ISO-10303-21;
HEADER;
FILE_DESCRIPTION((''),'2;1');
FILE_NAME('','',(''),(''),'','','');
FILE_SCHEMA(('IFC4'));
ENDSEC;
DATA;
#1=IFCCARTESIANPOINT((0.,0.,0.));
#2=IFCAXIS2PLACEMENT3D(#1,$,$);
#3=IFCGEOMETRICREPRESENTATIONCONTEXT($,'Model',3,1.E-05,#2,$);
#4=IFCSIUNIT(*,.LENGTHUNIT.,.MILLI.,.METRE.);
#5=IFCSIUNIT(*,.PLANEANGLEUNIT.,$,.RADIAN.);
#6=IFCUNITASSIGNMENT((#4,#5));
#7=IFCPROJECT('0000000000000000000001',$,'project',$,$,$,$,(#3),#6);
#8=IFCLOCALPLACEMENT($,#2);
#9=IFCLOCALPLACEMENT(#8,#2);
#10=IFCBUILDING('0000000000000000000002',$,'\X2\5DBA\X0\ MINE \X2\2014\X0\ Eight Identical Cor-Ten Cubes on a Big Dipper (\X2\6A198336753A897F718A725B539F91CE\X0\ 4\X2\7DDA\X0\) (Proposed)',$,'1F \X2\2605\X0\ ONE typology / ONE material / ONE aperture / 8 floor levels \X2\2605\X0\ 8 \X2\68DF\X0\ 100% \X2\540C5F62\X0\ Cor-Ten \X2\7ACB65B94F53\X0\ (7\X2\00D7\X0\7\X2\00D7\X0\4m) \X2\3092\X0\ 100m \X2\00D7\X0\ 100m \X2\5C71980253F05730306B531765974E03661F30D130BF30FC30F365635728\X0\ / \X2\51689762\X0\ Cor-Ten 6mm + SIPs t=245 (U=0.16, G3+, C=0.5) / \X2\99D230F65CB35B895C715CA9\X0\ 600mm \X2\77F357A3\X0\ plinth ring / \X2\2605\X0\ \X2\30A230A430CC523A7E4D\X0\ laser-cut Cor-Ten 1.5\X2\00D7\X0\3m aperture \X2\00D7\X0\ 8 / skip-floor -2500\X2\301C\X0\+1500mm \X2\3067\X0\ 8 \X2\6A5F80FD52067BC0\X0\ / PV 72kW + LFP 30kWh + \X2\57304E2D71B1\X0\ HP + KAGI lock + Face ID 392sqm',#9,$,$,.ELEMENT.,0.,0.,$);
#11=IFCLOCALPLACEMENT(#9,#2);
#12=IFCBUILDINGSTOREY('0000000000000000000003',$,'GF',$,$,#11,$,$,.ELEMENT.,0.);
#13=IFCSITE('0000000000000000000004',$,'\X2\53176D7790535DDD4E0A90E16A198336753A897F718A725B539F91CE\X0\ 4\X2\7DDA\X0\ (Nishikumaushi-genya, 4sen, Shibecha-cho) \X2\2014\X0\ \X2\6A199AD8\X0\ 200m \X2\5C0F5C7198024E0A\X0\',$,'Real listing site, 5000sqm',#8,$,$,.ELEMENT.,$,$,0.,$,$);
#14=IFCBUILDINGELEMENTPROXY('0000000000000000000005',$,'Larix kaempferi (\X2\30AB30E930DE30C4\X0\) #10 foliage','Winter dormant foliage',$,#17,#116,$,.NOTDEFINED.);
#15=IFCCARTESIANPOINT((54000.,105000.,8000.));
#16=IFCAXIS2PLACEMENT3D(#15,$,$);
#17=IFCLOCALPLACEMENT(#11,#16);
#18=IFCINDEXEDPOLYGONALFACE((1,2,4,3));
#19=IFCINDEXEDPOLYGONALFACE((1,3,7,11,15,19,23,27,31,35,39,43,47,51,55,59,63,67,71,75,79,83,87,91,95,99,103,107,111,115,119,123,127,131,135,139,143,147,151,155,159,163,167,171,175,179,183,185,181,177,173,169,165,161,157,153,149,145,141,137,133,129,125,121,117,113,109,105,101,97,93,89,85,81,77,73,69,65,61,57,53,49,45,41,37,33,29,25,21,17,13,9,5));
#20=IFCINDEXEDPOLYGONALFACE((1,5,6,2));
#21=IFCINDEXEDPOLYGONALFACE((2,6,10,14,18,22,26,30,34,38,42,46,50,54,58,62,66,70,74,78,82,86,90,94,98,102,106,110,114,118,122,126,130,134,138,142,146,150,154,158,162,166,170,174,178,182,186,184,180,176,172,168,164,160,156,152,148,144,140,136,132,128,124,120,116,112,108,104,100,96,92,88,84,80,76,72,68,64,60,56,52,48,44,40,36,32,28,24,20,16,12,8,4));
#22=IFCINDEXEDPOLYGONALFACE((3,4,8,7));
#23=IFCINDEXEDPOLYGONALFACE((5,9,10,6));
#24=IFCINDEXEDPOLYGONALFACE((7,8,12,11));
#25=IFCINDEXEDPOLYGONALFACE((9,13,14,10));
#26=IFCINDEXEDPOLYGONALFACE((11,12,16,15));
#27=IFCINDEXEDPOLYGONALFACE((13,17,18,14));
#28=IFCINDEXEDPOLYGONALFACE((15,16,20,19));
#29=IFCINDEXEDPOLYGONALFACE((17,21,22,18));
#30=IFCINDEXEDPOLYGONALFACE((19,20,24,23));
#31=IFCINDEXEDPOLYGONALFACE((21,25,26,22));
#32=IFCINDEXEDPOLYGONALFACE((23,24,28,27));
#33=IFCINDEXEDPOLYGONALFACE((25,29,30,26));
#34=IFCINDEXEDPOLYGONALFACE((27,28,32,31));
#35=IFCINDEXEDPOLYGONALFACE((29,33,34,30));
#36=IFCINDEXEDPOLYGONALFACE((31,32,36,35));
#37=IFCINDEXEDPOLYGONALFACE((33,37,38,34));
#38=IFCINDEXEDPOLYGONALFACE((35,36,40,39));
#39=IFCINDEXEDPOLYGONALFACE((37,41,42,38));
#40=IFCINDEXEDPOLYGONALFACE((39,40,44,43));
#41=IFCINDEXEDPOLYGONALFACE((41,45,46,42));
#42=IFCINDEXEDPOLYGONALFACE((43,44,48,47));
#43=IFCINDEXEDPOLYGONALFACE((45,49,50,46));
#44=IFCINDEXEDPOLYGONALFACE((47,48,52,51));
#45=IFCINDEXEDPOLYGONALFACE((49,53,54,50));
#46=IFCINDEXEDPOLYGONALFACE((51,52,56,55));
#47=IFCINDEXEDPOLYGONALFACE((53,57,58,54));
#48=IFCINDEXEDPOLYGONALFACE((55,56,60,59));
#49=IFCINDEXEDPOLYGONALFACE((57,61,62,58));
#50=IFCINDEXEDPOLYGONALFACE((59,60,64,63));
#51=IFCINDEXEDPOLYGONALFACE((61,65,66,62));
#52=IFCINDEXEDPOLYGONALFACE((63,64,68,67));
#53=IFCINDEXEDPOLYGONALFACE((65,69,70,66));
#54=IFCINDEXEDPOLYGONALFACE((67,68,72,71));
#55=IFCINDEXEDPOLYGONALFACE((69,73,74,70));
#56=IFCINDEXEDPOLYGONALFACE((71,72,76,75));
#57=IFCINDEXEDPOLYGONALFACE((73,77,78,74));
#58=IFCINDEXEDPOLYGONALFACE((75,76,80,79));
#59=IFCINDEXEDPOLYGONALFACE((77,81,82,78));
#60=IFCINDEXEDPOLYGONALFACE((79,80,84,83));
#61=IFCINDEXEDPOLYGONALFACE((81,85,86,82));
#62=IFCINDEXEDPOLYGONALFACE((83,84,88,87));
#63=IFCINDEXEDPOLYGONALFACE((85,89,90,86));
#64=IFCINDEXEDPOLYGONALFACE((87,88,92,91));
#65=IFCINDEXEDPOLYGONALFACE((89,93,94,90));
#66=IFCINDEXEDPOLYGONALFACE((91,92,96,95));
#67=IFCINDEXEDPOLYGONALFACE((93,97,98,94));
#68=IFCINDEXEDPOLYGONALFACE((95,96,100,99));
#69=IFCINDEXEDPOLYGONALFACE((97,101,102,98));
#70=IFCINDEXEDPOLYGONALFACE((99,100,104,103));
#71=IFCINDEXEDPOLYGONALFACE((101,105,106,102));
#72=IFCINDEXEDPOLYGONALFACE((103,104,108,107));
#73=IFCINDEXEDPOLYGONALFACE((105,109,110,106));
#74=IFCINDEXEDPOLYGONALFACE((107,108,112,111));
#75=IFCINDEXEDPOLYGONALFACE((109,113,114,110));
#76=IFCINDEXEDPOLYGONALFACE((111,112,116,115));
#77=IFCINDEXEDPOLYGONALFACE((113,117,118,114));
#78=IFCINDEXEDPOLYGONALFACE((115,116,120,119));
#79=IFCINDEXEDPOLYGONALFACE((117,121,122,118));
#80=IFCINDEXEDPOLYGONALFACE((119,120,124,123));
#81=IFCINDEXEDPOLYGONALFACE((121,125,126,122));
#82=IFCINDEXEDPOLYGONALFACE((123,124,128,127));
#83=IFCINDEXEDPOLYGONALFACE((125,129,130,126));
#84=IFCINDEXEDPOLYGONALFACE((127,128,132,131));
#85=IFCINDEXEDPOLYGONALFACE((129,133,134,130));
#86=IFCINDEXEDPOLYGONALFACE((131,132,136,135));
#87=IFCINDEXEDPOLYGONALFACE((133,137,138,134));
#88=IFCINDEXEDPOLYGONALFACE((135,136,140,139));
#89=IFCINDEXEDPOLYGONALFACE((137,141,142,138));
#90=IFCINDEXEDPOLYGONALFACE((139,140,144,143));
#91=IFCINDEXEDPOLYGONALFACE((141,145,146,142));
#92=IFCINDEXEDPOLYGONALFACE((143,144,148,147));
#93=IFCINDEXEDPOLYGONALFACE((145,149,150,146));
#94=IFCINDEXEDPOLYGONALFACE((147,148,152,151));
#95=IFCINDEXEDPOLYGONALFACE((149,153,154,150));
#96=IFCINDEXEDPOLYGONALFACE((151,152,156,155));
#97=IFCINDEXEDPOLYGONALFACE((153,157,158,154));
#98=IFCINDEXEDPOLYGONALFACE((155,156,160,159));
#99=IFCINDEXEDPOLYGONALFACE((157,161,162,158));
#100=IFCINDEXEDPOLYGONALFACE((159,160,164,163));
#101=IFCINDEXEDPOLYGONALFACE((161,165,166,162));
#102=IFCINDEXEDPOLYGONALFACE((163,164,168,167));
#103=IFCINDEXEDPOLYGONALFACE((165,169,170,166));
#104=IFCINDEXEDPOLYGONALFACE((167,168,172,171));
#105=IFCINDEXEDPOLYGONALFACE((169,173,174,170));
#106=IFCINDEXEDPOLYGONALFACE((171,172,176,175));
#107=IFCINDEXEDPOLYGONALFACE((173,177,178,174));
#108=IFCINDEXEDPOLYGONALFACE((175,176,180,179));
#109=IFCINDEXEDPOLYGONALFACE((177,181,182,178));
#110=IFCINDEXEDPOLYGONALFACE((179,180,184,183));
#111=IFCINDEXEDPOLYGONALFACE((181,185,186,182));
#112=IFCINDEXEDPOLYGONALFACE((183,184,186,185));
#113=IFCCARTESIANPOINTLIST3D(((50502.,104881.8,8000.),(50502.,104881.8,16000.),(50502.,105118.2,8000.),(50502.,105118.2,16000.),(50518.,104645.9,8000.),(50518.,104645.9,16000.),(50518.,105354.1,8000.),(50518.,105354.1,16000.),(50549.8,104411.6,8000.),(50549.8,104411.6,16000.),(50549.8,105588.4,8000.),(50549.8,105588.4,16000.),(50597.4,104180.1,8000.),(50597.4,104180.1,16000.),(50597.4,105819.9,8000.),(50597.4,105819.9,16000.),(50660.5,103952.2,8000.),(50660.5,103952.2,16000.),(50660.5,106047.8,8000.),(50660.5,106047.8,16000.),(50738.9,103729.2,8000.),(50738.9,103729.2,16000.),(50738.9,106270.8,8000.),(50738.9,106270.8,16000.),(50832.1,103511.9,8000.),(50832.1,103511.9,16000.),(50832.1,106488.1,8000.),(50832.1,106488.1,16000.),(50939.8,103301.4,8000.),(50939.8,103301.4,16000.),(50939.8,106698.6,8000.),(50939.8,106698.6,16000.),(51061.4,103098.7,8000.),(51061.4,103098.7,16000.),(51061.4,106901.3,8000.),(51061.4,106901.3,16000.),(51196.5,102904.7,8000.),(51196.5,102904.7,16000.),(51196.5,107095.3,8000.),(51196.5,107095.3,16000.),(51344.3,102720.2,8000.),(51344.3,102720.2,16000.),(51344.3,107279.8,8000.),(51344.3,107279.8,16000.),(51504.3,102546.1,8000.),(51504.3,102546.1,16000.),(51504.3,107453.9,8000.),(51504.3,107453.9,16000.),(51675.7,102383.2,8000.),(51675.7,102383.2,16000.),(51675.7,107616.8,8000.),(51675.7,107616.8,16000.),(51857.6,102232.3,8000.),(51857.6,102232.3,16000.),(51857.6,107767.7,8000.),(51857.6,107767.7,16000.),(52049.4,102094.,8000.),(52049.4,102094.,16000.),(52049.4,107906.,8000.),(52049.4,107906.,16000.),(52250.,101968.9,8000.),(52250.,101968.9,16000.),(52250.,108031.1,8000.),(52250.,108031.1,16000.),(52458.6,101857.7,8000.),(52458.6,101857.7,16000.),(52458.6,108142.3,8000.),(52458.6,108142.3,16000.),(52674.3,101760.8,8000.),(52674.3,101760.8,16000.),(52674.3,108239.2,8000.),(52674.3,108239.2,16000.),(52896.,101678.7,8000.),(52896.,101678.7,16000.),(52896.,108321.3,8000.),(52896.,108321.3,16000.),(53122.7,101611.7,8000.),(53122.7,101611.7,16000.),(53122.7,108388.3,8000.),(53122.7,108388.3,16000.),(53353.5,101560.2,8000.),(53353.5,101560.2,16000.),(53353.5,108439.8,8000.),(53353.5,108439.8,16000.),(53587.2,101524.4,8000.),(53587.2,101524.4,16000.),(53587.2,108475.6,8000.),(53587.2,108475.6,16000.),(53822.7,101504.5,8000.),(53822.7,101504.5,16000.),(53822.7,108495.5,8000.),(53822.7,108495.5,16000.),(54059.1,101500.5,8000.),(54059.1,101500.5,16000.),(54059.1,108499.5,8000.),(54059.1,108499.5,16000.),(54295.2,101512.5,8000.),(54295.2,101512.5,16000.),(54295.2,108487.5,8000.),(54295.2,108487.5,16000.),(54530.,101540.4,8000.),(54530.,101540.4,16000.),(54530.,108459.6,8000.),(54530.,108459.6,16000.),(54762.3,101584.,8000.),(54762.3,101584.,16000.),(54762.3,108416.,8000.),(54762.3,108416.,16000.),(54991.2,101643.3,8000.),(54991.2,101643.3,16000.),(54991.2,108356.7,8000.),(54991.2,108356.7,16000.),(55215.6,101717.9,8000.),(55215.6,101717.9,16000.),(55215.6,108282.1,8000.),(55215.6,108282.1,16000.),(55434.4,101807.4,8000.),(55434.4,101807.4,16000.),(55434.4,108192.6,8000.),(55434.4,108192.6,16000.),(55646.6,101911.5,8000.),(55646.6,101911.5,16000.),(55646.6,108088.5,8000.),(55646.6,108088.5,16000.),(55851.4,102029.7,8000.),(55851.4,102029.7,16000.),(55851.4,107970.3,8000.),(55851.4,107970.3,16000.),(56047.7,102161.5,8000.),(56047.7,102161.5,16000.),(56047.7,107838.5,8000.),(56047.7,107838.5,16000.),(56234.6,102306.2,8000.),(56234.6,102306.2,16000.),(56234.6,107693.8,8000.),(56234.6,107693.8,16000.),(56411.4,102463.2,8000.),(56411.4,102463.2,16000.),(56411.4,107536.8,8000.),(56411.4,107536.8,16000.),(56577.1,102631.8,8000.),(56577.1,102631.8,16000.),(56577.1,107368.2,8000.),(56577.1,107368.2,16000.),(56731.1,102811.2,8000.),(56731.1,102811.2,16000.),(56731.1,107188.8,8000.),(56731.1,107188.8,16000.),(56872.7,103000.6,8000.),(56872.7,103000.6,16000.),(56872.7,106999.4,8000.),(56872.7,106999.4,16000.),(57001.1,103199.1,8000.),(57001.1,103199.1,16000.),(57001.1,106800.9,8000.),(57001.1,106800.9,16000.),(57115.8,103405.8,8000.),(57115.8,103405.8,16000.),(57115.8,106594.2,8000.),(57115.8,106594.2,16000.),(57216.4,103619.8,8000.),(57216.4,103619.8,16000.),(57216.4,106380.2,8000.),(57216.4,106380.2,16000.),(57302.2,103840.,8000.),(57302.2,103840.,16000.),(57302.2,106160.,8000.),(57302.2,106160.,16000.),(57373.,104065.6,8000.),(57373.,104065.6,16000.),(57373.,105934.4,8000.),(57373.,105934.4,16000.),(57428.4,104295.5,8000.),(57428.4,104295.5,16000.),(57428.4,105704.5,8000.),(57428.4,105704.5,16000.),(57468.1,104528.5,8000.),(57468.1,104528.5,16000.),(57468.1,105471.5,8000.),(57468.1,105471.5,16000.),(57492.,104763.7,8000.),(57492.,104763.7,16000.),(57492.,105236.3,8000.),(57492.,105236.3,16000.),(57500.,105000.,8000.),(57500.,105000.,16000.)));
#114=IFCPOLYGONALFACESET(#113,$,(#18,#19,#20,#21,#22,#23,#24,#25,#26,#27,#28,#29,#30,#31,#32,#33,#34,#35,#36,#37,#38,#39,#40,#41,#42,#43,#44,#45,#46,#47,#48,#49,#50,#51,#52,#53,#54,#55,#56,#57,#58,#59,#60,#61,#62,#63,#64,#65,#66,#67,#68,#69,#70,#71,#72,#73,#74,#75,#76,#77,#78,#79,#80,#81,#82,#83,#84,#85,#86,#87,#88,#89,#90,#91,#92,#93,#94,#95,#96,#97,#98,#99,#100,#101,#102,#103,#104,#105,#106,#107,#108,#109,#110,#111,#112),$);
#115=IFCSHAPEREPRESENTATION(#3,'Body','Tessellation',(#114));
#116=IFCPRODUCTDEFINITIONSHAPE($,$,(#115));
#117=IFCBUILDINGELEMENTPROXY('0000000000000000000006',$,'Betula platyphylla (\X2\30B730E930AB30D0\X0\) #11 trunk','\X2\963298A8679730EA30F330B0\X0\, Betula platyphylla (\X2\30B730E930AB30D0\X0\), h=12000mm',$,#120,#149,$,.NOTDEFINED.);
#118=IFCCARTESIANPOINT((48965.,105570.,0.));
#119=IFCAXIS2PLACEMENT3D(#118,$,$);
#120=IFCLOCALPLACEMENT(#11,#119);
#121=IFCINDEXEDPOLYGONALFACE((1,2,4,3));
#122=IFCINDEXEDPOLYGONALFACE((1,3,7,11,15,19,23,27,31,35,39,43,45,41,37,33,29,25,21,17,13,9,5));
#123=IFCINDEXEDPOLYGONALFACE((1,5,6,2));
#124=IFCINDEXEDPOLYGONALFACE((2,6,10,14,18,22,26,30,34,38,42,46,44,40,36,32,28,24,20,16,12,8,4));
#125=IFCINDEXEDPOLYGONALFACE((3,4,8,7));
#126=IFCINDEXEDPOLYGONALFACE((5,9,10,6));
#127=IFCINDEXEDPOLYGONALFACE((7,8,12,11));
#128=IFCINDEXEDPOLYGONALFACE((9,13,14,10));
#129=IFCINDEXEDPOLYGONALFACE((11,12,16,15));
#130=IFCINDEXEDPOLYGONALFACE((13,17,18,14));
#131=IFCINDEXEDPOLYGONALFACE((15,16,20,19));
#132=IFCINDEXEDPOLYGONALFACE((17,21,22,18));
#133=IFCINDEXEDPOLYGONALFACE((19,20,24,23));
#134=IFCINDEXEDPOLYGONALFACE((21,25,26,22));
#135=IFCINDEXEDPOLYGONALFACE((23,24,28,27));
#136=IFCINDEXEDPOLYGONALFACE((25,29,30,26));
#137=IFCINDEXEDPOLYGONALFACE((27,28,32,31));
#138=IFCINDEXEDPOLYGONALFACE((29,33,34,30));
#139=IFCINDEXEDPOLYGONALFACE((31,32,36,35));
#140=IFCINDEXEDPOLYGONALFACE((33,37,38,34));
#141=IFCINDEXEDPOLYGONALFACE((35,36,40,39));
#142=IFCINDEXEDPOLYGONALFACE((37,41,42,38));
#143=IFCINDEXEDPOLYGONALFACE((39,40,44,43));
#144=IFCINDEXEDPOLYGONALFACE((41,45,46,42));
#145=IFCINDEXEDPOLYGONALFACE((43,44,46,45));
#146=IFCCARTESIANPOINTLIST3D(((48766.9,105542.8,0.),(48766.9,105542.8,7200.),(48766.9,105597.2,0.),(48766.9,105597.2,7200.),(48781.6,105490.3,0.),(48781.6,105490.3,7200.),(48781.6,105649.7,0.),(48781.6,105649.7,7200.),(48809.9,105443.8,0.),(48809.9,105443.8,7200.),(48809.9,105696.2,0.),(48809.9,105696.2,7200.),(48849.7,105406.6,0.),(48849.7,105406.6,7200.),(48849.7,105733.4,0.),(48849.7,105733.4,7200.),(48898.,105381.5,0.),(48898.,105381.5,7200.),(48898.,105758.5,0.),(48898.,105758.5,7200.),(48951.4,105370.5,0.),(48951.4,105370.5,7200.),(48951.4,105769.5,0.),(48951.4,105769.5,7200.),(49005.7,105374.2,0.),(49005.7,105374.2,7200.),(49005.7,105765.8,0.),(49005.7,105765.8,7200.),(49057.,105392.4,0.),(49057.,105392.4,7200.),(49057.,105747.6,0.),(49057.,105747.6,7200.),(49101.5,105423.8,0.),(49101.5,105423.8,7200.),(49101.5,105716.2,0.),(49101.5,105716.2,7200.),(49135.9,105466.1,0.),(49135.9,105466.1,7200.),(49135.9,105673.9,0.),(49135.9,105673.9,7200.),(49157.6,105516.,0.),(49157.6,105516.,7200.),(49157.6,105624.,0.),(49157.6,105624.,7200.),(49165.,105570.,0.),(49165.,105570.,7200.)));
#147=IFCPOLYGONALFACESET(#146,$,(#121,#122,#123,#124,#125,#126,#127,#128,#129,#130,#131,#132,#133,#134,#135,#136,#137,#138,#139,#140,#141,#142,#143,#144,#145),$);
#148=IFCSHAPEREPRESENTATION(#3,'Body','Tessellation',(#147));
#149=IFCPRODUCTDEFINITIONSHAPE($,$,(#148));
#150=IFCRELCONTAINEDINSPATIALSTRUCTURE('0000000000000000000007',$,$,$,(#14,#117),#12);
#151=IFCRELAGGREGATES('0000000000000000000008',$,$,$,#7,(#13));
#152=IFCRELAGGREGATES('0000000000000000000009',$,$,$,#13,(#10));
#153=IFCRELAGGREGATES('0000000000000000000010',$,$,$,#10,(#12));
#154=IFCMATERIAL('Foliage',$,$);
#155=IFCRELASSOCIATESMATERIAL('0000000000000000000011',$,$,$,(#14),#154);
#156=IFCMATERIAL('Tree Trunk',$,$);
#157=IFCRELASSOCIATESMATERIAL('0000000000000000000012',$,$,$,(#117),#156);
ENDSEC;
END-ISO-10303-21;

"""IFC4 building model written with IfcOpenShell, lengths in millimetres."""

from ifc_helpers import new_model, si_unit, frame, origin, origin_2d, place, context, project, spatial, circle, extrude, material, element, save


model = new_model("IFC4")

# Units and contexts
model_context = context("Model", 3, precision=1e-05, world=origin())
ifc_project = project(units=[si_unit("LENGTHUNIT", "METRE", prefix="MILLI"), si_unit("PLANEANGLEUNIT", "RADIAN")], contexts=[model_context])

# Site, building, storey
site_placement = place(None, origin())
site = spatial("IfcSite", under=ifc_project, at=site_placement, Name="北海道川上郡標茶町西熊牛原野 4線 (Nishikumaushi-genya, 4sen, Shibecha-cho) — 標高 200m 小山頂上", ObjectType="Real listing site, 5000sqm", CompositionType="ELEMENT", RefElevation=0.0)
building_placement = place(site_placement, origin())
building = spatial("IfcBuilding", under=site, at=building_placement, Name="嶺 MINE — Eight Identical Cor-Ten Cubes on a Big Dipper (標茶町西熊牛原野 4線) (Proposed)", ObjectType="1F ★ ONE typology / ONE material / ONE aperture / 8 floor levels ★ 8 棟 100% 同形 Cor-Ten 立方体 (7×7×4m) を 100m × 100m 山頂台地に北斗七星パターン散在 / 全面 Cor-Ten 6mm + SIPs t=245 (U=0.16, G3+, C=0.5) / 駒ヶ岳安山岩 600mm 石垣 plinth ring / ★ アイヌ刺繍 laser-cut Cor-Ten 1.5×3m aperture × 8 / skip-floor -2500〜+1500mm で 8 機能分節 / PV 72kW + LFP 30kWh + 地中熱 HP + KAGI lock + Face ID 392sqm", CompositionType="ELEMENT", ElevationOfRefHeight=0.0, ElevationOfTerrain=0.0)
storey_placement = place(building_placement, origin())
storey = spatial("IfcBuildingStorey", under=building, at=storey_placement, Name="GF", CompositionType="ELEMENT", Elevation=0.0)

# Building element proxies
ifc_material_1 = material(Name="Tree Trunk")
ifc_material_2 = material(Name="Foliage")
proxy_1_placement = place(storey_placement, frame((54000.0, 105000.0, 8000.0)))
element("IfcBuildingElementProxy", 1, at=proxy_1_placement, inside=storey, material=ifc_material_2, Name="Larix kaempferi (カラマツ) #10 foliage", Description="Winter dormant foliage", PredefinedType="NOTDEFINED", context=model_context, shape_type="SweptSolid", body=[
    extrude(circle(Radius=3500.0, at=origin_2d()), frame((54000.0, 105000.0, 8000.0)), (0.0, 0.0, 1.0), 8000.0),
])
proxy_2_placement = place(storey_placement, frame((48965.0, 105570.0, 0.0)))
element("IfcBuildingElementProxy", 2, at=proxy_2_placement, inside=storey, material=ifc_material_1, Name="Betula platyphylla (シラカバ) #11 trunk", Description="防風林リング, Betula platyphylla (シラカバ), h=12000mm", PredefinedType="NOTDEFINED", context=model_context, shape_type="SweptSolid", body=[
    extrude(circle(Radius=200.0, at=origin_2d()), frame((48965.0, 105570.0, 0.0)), (0.0, 0.0, 1.0), 7200.0),
])

save(model, "model.ifc")
